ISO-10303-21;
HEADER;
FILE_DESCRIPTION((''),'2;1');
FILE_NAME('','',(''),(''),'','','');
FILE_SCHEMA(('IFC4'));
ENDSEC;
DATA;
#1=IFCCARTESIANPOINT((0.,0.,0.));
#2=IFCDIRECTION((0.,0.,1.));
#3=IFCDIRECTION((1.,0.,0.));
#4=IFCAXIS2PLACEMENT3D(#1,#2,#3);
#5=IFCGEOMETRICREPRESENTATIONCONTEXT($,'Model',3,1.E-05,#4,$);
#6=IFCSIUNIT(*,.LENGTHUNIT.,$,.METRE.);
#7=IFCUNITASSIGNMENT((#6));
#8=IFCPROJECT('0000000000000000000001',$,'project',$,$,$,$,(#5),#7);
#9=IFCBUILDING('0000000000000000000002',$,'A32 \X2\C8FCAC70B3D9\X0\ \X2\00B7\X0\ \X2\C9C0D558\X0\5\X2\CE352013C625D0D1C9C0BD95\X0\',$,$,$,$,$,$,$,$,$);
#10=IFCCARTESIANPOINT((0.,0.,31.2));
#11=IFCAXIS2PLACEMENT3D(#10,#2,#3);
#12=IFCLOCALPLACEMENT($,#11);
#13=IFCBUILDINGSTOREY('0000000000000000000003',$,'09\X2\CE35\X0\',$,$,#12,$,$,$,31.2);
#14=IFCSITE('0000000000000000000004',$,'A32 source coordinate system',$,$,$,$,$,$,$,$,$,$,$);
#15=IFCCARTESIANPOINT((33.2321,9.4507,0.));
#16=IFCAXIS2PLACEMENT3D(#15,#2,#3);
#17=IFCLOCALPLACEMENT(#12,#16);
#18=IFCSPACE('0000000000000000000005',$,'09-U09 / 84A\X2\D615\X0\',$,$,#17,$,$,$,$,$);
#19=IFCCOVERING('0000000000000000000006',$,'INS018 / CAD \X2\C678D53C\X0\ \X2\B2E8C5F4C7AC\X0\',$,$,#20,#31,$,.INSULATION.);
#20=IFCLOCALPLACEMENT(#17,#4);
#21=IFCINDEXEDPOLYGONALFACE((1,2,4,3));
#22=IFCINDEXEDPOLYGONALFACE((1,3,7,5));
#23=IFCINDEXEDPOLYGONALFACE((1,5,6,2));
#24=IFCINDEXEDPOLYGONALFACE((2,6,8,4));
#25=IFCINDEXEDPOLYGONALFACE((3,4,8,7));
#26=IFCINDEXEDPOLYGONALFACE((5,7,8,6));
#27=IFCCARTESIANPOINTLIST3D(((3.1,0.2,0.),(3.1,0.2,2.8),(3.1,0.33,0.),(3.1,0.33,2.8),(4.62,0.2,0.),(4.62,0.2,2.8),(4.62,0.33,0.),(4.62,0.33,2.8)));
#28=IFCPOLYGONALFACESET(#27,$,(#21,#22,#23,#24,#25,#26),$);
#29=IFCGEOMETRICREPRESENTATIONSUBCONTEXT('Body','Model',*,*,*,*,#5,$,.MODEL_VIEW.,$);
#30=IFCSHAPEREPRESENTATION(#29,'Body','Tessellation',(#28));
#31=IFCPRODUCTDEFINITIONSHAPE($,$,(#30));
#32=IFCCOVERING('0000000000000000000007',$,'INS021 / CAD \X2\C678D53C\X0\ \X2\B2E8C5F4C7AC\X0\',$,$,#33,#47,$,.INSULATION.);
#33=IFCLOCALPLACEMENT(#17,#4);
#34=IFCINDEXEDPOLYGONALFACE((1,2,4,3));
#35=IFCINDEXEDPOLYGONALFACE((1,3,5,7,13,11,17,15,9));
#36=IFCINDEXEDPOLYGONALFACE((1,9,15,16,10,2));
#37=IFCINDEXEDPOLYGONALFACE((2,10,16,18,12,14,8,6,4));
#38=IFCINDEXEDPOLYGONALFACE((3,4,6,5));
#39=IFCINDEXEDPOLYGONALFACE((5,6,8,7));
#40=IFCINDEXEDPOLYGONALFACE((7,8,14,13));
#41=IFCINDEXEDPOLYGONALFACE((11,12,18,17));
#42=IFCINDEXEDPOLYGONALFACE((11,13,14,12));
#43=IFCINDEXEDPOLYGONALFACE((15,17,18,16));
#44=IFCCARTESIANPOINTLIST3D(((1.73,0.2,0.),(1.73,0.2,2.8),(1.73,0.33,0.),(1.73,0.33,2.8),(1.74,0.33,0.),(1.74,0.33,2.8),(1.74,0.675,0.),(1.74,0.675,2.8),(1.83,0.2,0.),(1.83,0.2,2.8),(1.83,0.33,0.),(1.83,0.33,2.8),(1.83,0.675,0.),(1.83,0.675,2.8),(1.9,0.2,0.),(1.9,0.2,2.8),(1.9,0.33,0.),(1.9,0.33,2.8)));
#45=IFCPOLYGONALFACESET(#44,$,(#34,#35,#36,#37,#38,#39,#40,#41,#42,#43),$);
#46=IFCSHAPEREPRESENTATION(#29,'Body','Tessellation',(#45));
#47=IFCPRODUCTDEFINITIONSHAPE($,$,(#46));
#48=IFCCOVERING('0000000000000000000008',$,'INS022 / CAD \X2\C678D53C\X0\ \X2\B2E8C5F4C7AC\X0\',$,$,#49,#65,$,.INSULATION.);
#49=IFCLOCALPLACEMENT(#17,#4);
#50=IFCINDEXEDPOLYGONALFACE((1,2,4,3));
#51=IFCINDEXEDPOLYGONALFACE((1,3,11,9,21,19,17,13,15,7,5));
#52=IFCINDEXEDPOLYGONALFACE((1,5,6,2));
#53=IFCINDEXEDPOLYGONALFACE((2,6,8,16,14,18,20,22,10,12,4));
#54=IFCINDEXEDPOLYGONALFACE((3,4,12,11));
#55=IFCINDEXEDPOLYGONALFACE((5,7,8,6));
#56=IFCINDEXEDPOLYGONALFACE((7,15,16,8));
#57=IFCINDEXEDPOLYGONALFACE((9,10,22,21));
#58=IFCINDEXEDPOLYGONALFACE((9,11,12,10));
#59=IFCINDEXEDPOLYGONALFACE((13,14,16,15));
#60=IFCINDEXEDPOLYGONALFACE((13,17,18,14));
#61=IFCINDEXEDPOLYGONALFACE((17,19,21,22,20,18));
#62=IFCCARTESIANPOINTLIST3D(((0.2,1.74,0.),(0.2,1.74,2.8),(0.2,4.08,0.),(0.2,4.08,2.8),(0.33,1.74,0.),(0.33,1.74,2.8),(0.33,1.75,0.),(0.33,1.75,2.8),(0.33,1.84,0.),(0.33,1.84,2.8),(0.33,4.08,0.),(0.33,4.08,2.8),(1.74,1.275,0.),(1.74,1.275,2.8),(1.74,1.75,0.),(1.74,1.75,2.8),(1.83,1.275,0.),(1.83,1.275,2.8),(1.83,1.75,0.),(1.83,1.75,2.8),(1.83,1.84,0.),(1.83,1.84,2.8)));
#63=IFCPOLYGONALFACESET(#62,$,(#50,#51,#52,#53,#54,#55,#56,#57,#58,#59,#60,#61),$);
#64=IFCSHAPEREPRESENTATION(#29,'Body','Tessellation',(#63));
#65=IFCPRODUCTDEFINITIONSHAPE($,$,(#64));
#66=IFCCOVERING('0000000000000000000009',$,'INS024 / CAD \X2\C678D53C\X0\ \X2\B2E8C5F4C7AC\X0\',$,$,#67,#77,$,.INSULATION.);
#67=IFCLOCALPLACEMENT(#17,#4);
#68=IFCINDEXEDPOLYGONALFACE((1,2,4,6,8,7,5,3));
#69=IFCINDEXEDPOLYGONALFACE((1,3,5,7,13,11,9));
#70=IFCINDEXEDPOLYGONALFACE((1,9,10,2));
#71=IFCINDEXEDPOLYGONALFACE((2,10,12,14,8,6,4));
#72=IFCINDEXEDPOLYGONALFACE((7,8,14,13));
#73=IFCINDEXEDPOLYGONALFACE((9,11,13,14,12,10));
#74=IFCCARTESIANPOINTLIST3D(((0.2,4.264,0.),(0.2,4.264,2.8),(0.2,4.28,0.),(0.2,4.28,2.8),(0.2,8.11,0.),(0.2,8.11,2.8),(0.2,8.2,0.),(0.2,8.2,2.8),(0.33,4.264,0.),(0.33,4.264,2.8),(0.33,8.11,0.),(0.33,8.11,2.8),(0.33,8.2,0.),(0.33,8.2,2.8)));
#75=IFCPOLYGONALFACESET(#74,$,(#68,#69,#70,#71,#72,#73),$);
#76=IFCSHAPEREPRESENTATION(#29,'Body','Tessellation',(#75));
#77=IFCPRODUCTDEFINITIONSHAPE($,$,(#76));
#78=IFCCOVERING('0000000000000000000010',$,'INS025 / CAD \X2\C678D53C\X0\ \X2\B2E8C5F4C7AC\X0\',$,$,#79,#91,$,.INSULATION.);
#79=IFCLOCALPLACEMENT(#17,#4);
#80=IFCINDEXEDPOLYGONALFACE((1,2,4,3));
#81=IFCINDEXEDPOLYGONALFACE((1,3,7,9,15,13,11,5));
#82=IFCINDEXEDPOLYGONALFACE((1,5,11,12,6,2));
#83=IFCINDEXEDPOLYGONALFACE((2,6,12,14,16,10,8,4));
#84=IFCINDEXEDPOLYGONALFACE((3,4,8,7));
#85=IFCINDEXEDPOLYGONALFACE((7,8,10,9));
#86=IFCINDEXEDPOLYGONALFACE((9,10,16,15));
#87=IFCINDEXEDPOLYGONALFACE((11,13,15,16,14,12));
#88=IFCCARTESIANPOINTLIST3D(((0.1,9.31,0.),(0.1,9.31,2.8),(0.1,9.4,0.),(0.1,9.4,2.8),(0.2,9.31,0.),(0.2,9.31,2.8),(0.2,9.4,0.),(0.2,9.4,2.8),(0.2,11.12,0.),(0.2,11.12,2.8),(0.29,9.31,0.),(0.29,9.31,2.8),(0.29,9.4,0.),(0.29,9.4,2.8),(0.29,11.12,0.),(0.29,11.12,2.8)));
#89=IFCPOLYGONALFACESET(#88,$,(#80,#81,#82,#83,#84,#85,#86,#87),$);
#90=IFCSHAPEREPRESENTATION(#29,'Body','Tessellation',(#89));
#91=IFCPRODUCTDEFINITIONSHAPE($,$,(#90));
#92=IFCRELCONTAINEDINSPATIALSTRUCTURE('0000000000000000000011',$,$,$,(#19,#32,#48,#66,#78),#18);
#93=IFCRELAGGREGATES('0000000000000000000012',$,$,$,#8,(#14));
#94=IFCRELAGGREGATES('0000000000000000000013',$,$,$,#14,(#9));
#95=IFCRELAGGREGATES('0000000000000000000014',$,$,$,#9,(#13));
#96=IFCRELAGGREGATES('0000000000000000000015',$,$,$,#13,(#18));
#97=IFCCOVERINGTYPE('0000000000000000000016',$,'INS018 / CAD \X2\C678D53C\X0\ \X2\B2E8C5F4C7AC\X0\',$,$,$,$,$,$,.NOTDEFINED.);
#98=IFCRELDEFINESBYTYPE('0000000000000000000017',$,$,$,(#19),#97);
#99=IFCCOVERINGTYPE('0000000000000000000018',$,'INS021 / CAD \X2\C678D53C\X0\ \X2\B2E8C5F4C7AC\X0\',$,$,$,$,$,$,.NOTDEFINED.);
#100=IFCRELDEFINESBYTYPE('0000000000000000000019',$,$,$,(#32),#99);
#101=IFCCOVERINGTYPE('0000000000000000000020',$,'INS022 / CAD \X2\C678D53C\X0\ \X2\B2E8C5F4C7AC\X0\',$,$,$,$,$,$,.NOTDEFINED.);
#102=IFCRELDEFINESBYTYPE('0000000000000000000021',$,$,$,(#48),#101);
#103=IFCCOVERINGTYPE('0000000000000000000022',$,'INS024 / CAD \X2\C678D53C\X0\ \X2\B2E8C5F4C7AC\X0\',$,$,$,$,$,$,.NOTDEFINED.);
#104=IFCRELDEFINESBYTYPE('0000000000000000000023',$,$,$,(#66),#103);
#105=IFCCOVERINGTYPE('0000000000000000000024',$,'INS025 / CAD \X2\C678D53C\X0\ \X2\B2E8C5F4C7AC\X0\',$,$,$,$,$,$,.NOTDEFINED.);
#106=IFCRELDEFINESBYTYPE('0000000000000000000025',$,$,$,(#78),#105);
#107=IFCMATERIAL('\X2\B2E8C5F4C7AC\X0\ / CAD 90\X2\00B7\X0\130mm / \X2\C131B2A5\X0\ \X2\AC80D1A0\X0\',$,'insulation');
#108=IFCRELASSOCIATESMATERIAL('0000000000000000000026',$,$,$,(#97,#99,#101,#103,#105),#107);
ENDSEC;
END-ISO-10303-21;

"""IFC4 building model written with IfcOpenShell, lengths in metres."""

from ifc_helpers import new_model, si_unit, frame, origin, origin_with_axes, place, context, subcontext, project, spatial, polyline, outline, extrude, source, transform, mapped, material, type_object, type_shapes, element, save


model = new_model("IFC4")

# Units and contexts
model_context = context("Model", 3, precision=1e-05, world=origin_with_axes())
body_context = subcontext(model_context, "Body", "Model", "MODEL_VIEW")
ifc_project = project(units=[si_unit("LENGTHUNIT", "METRE")], contexts=[model_context])

# Site, building, storey, space
storey_placement = place(None, frame((0.0, 0.0, 31.2), z_axis=(0.0, 0.0, 1.0), x_axis=(1.0, 0.0, 0.0)))
space_placement = place(storey_placement, frame((33.2321, 9.4507, 0.0), z_axis=(0.0, 0.0, 1.0), x_axis=(1.0, 0.0, 0.0)))
site = spatial("IfcSite", under=ifc_project, Name="A32 source coordinate system")
building = spatial("IfcBuilding", under=site, Name="A32 주거동 · 지하5층–옥탑지붕")
storey = spatial("IfcBuildingStorey", under=building, at=storey_placement, Name="09층", Elevation=31.2)
space = spatial("IfcSpace", under=storey, at=space_placement, Name="09-U09 / 84A형")

# Coverings
ifc_material = material(Name="단열재 / CAD 90·130mm / 성능 검토", Category="insulation")
covering_type_1 = type_object("IfcCoveringType", Name="INS018 / CAD 외피 단열재", PredefinedType="NOTDEFINED", material=ifc_material)
shared_shape_1 = source(origin(), body_context, "Body", "SweptSolid", [
    extrude(outline(polyline([(3.1, 0.33), (4.62, 0.33), (4.62, 0.2), (3.1, 0.2), (3.1, 0.33)])), origin(), (0.0, 0.0, 1.0), 2.8),
])
type_shapes(covering_type_1, [shared_shape_1])
covering_1_placement = place(space_placement, origin_with_axes())
element("IfcCovering", 1, at=covering_1_placement, inside=space, type_object=covering_type_1, Name="INS018 / CAD 외피 단열재", PredefinedType="INSULATION", context=body_context, shape_type="MappedRepresentation", body=[
    mapped(shared_shape_1, transform((0.0, 0.0, 0.0), scale=1.0)),
])
covering_type_2 = type_object("IfcCoveringType", Name="INS021 / CAD 외피 단열재", PredefinedType="NOTDEFINED", material=ifc_material)
shared_shape_2 = source(origin(), body_context, "Body", "SweptSolid", [
    extrude(outline(polyline([(1.83, 0.33), (1.9, 0.33), (1.9, 0.2), (1.83, 0.2), (1.73, 0.2), (1.73, 0.33), (1.74, 0.33), (1.74, 0.675), (1.83, 0.675), (1.83, 0.33)])), origin(), (0.0, 0.0, 1.0), 2.8),
])
type_shapes(covering_type_2, [shared_shape_2])
covering_2_placement = place(space_placement, origin_with_axes())
element("IfcCovering", 2, at=covering_2_placement, inside=space, type_object=covering_type_2, Name="INS021 / CAD 외피 단열재", PredefinedType="INSULATION", context=body_context, shape_type="MappedRepresentation", body=[
    mapped(shared_shape_2, transform((0.0, 0.0, 0.0), scale=1.0)),
])
covering_type_3 = type_object("IfcCoveringType", Name="INS022 / CAD 외피 단열재", PredefinedType="NOTDEFINED", material=ifc_material)
shared_shape_3 = source(origin(), body_context, "Body", "SweptSolid", [
    extrude(outline(polyline([(1.83, 1.84), (1.83, 1.75), (1.83, 1.275), (1.74, 1.275), (1.74, 1.75), (0.33, 1.75), (0.33, 1.74), (0.2, 1.74), (0.2, 4.08), (0.33, 4.08), (0.33, 1.84), (1.83, 1.84)])), origin(), (0.0, 0.0, 1.0), 2.8),
])
type_shapes(covering_type_3, [shared_shape_3])
covering_3_placement = place(space_placement, origin_with_axes())
element("IfcCovering", 3, at=covering_3_placement, inside=space, type_object=covering_type_3, Name="INS022 / CAD 외피 단열재", PredefinedType="INSULATION", context=body_context, shape_type="MappedRepresentation", body=[
    mapped(shared_shape_3, transform((0.0, 0.0, 0.0), scale=1.0)),
])
covering_type_4 = type_object("IfcCoveringType", Name="INS024 / CAD 외피 단열재", PredefinedType="NOTDEFINED", material=ifc_material)
shared_shape_4 = source(origin(), body_context, "Body", "SweptSolid", [
    extrude(outline(polyline([(0.2, 8.11), (0.2, 8.2), (0.33, 8.2), (0.33, 8.11), (0.33, 4.264), (0.2, 4.264), (0.2, 4.28), (0.2, 8.11)])), origin(), (0.0, 0.0, 1.0), 2.8),
])
type_shapes(covering_type_4, [shared_shape_4])
covering_4_placement = place(space_placement, origin_with_axes())
element("IfcCovering", 4, at=covering_4_placement, inside=space, type_object=covering_type_4, Name="INS024 / CAD 외피 단열재", PredefinedType="INSULATION", context=body_context, shape_type="MappedRepresentation", body=[
    mapped(shared_shape_4, transform((0.0, 0.0, 0.0), scale=1.0)),
])
covering_type_5 = type_object("IfcCoveringType", Name="INS025 / CAD 외피 단열재", PredefinedType="NOTDEFINED", material=ifc_material)
shared_shape_5 = source(origin(), body_context, "Body", "SweptSolid", [
    extrude(outline(polyline([(0.2, 9.4), (0.2, 11.12), (0.29, 11.12), (0.29, 9.4), (0.29, 9.31), (0.2, 9.31), (0.1, 9.31), (0.1, 9.4), (0.2, 9.4)])), origin(), (0.0, 0.0, 1.0), 2.8),
])
type_shapes(covering_type_5, [shared_shape_5])
covering_5_placement = place(space_placement, origin_with_axes())
element("IfcCovering", 5, at=covering_5_placement, inside=space, type_object=covering_type_5, Name="INS025 / CAD 외피 단열재", PredefinedType="INSULATION", context=body_context, shape_type="MappedRepresentation", body=[
    mapped(shared_shape_5, transform((0.0, 0.0, 0.0), scale=1.0)),
])

save(model, "model.ifc")
